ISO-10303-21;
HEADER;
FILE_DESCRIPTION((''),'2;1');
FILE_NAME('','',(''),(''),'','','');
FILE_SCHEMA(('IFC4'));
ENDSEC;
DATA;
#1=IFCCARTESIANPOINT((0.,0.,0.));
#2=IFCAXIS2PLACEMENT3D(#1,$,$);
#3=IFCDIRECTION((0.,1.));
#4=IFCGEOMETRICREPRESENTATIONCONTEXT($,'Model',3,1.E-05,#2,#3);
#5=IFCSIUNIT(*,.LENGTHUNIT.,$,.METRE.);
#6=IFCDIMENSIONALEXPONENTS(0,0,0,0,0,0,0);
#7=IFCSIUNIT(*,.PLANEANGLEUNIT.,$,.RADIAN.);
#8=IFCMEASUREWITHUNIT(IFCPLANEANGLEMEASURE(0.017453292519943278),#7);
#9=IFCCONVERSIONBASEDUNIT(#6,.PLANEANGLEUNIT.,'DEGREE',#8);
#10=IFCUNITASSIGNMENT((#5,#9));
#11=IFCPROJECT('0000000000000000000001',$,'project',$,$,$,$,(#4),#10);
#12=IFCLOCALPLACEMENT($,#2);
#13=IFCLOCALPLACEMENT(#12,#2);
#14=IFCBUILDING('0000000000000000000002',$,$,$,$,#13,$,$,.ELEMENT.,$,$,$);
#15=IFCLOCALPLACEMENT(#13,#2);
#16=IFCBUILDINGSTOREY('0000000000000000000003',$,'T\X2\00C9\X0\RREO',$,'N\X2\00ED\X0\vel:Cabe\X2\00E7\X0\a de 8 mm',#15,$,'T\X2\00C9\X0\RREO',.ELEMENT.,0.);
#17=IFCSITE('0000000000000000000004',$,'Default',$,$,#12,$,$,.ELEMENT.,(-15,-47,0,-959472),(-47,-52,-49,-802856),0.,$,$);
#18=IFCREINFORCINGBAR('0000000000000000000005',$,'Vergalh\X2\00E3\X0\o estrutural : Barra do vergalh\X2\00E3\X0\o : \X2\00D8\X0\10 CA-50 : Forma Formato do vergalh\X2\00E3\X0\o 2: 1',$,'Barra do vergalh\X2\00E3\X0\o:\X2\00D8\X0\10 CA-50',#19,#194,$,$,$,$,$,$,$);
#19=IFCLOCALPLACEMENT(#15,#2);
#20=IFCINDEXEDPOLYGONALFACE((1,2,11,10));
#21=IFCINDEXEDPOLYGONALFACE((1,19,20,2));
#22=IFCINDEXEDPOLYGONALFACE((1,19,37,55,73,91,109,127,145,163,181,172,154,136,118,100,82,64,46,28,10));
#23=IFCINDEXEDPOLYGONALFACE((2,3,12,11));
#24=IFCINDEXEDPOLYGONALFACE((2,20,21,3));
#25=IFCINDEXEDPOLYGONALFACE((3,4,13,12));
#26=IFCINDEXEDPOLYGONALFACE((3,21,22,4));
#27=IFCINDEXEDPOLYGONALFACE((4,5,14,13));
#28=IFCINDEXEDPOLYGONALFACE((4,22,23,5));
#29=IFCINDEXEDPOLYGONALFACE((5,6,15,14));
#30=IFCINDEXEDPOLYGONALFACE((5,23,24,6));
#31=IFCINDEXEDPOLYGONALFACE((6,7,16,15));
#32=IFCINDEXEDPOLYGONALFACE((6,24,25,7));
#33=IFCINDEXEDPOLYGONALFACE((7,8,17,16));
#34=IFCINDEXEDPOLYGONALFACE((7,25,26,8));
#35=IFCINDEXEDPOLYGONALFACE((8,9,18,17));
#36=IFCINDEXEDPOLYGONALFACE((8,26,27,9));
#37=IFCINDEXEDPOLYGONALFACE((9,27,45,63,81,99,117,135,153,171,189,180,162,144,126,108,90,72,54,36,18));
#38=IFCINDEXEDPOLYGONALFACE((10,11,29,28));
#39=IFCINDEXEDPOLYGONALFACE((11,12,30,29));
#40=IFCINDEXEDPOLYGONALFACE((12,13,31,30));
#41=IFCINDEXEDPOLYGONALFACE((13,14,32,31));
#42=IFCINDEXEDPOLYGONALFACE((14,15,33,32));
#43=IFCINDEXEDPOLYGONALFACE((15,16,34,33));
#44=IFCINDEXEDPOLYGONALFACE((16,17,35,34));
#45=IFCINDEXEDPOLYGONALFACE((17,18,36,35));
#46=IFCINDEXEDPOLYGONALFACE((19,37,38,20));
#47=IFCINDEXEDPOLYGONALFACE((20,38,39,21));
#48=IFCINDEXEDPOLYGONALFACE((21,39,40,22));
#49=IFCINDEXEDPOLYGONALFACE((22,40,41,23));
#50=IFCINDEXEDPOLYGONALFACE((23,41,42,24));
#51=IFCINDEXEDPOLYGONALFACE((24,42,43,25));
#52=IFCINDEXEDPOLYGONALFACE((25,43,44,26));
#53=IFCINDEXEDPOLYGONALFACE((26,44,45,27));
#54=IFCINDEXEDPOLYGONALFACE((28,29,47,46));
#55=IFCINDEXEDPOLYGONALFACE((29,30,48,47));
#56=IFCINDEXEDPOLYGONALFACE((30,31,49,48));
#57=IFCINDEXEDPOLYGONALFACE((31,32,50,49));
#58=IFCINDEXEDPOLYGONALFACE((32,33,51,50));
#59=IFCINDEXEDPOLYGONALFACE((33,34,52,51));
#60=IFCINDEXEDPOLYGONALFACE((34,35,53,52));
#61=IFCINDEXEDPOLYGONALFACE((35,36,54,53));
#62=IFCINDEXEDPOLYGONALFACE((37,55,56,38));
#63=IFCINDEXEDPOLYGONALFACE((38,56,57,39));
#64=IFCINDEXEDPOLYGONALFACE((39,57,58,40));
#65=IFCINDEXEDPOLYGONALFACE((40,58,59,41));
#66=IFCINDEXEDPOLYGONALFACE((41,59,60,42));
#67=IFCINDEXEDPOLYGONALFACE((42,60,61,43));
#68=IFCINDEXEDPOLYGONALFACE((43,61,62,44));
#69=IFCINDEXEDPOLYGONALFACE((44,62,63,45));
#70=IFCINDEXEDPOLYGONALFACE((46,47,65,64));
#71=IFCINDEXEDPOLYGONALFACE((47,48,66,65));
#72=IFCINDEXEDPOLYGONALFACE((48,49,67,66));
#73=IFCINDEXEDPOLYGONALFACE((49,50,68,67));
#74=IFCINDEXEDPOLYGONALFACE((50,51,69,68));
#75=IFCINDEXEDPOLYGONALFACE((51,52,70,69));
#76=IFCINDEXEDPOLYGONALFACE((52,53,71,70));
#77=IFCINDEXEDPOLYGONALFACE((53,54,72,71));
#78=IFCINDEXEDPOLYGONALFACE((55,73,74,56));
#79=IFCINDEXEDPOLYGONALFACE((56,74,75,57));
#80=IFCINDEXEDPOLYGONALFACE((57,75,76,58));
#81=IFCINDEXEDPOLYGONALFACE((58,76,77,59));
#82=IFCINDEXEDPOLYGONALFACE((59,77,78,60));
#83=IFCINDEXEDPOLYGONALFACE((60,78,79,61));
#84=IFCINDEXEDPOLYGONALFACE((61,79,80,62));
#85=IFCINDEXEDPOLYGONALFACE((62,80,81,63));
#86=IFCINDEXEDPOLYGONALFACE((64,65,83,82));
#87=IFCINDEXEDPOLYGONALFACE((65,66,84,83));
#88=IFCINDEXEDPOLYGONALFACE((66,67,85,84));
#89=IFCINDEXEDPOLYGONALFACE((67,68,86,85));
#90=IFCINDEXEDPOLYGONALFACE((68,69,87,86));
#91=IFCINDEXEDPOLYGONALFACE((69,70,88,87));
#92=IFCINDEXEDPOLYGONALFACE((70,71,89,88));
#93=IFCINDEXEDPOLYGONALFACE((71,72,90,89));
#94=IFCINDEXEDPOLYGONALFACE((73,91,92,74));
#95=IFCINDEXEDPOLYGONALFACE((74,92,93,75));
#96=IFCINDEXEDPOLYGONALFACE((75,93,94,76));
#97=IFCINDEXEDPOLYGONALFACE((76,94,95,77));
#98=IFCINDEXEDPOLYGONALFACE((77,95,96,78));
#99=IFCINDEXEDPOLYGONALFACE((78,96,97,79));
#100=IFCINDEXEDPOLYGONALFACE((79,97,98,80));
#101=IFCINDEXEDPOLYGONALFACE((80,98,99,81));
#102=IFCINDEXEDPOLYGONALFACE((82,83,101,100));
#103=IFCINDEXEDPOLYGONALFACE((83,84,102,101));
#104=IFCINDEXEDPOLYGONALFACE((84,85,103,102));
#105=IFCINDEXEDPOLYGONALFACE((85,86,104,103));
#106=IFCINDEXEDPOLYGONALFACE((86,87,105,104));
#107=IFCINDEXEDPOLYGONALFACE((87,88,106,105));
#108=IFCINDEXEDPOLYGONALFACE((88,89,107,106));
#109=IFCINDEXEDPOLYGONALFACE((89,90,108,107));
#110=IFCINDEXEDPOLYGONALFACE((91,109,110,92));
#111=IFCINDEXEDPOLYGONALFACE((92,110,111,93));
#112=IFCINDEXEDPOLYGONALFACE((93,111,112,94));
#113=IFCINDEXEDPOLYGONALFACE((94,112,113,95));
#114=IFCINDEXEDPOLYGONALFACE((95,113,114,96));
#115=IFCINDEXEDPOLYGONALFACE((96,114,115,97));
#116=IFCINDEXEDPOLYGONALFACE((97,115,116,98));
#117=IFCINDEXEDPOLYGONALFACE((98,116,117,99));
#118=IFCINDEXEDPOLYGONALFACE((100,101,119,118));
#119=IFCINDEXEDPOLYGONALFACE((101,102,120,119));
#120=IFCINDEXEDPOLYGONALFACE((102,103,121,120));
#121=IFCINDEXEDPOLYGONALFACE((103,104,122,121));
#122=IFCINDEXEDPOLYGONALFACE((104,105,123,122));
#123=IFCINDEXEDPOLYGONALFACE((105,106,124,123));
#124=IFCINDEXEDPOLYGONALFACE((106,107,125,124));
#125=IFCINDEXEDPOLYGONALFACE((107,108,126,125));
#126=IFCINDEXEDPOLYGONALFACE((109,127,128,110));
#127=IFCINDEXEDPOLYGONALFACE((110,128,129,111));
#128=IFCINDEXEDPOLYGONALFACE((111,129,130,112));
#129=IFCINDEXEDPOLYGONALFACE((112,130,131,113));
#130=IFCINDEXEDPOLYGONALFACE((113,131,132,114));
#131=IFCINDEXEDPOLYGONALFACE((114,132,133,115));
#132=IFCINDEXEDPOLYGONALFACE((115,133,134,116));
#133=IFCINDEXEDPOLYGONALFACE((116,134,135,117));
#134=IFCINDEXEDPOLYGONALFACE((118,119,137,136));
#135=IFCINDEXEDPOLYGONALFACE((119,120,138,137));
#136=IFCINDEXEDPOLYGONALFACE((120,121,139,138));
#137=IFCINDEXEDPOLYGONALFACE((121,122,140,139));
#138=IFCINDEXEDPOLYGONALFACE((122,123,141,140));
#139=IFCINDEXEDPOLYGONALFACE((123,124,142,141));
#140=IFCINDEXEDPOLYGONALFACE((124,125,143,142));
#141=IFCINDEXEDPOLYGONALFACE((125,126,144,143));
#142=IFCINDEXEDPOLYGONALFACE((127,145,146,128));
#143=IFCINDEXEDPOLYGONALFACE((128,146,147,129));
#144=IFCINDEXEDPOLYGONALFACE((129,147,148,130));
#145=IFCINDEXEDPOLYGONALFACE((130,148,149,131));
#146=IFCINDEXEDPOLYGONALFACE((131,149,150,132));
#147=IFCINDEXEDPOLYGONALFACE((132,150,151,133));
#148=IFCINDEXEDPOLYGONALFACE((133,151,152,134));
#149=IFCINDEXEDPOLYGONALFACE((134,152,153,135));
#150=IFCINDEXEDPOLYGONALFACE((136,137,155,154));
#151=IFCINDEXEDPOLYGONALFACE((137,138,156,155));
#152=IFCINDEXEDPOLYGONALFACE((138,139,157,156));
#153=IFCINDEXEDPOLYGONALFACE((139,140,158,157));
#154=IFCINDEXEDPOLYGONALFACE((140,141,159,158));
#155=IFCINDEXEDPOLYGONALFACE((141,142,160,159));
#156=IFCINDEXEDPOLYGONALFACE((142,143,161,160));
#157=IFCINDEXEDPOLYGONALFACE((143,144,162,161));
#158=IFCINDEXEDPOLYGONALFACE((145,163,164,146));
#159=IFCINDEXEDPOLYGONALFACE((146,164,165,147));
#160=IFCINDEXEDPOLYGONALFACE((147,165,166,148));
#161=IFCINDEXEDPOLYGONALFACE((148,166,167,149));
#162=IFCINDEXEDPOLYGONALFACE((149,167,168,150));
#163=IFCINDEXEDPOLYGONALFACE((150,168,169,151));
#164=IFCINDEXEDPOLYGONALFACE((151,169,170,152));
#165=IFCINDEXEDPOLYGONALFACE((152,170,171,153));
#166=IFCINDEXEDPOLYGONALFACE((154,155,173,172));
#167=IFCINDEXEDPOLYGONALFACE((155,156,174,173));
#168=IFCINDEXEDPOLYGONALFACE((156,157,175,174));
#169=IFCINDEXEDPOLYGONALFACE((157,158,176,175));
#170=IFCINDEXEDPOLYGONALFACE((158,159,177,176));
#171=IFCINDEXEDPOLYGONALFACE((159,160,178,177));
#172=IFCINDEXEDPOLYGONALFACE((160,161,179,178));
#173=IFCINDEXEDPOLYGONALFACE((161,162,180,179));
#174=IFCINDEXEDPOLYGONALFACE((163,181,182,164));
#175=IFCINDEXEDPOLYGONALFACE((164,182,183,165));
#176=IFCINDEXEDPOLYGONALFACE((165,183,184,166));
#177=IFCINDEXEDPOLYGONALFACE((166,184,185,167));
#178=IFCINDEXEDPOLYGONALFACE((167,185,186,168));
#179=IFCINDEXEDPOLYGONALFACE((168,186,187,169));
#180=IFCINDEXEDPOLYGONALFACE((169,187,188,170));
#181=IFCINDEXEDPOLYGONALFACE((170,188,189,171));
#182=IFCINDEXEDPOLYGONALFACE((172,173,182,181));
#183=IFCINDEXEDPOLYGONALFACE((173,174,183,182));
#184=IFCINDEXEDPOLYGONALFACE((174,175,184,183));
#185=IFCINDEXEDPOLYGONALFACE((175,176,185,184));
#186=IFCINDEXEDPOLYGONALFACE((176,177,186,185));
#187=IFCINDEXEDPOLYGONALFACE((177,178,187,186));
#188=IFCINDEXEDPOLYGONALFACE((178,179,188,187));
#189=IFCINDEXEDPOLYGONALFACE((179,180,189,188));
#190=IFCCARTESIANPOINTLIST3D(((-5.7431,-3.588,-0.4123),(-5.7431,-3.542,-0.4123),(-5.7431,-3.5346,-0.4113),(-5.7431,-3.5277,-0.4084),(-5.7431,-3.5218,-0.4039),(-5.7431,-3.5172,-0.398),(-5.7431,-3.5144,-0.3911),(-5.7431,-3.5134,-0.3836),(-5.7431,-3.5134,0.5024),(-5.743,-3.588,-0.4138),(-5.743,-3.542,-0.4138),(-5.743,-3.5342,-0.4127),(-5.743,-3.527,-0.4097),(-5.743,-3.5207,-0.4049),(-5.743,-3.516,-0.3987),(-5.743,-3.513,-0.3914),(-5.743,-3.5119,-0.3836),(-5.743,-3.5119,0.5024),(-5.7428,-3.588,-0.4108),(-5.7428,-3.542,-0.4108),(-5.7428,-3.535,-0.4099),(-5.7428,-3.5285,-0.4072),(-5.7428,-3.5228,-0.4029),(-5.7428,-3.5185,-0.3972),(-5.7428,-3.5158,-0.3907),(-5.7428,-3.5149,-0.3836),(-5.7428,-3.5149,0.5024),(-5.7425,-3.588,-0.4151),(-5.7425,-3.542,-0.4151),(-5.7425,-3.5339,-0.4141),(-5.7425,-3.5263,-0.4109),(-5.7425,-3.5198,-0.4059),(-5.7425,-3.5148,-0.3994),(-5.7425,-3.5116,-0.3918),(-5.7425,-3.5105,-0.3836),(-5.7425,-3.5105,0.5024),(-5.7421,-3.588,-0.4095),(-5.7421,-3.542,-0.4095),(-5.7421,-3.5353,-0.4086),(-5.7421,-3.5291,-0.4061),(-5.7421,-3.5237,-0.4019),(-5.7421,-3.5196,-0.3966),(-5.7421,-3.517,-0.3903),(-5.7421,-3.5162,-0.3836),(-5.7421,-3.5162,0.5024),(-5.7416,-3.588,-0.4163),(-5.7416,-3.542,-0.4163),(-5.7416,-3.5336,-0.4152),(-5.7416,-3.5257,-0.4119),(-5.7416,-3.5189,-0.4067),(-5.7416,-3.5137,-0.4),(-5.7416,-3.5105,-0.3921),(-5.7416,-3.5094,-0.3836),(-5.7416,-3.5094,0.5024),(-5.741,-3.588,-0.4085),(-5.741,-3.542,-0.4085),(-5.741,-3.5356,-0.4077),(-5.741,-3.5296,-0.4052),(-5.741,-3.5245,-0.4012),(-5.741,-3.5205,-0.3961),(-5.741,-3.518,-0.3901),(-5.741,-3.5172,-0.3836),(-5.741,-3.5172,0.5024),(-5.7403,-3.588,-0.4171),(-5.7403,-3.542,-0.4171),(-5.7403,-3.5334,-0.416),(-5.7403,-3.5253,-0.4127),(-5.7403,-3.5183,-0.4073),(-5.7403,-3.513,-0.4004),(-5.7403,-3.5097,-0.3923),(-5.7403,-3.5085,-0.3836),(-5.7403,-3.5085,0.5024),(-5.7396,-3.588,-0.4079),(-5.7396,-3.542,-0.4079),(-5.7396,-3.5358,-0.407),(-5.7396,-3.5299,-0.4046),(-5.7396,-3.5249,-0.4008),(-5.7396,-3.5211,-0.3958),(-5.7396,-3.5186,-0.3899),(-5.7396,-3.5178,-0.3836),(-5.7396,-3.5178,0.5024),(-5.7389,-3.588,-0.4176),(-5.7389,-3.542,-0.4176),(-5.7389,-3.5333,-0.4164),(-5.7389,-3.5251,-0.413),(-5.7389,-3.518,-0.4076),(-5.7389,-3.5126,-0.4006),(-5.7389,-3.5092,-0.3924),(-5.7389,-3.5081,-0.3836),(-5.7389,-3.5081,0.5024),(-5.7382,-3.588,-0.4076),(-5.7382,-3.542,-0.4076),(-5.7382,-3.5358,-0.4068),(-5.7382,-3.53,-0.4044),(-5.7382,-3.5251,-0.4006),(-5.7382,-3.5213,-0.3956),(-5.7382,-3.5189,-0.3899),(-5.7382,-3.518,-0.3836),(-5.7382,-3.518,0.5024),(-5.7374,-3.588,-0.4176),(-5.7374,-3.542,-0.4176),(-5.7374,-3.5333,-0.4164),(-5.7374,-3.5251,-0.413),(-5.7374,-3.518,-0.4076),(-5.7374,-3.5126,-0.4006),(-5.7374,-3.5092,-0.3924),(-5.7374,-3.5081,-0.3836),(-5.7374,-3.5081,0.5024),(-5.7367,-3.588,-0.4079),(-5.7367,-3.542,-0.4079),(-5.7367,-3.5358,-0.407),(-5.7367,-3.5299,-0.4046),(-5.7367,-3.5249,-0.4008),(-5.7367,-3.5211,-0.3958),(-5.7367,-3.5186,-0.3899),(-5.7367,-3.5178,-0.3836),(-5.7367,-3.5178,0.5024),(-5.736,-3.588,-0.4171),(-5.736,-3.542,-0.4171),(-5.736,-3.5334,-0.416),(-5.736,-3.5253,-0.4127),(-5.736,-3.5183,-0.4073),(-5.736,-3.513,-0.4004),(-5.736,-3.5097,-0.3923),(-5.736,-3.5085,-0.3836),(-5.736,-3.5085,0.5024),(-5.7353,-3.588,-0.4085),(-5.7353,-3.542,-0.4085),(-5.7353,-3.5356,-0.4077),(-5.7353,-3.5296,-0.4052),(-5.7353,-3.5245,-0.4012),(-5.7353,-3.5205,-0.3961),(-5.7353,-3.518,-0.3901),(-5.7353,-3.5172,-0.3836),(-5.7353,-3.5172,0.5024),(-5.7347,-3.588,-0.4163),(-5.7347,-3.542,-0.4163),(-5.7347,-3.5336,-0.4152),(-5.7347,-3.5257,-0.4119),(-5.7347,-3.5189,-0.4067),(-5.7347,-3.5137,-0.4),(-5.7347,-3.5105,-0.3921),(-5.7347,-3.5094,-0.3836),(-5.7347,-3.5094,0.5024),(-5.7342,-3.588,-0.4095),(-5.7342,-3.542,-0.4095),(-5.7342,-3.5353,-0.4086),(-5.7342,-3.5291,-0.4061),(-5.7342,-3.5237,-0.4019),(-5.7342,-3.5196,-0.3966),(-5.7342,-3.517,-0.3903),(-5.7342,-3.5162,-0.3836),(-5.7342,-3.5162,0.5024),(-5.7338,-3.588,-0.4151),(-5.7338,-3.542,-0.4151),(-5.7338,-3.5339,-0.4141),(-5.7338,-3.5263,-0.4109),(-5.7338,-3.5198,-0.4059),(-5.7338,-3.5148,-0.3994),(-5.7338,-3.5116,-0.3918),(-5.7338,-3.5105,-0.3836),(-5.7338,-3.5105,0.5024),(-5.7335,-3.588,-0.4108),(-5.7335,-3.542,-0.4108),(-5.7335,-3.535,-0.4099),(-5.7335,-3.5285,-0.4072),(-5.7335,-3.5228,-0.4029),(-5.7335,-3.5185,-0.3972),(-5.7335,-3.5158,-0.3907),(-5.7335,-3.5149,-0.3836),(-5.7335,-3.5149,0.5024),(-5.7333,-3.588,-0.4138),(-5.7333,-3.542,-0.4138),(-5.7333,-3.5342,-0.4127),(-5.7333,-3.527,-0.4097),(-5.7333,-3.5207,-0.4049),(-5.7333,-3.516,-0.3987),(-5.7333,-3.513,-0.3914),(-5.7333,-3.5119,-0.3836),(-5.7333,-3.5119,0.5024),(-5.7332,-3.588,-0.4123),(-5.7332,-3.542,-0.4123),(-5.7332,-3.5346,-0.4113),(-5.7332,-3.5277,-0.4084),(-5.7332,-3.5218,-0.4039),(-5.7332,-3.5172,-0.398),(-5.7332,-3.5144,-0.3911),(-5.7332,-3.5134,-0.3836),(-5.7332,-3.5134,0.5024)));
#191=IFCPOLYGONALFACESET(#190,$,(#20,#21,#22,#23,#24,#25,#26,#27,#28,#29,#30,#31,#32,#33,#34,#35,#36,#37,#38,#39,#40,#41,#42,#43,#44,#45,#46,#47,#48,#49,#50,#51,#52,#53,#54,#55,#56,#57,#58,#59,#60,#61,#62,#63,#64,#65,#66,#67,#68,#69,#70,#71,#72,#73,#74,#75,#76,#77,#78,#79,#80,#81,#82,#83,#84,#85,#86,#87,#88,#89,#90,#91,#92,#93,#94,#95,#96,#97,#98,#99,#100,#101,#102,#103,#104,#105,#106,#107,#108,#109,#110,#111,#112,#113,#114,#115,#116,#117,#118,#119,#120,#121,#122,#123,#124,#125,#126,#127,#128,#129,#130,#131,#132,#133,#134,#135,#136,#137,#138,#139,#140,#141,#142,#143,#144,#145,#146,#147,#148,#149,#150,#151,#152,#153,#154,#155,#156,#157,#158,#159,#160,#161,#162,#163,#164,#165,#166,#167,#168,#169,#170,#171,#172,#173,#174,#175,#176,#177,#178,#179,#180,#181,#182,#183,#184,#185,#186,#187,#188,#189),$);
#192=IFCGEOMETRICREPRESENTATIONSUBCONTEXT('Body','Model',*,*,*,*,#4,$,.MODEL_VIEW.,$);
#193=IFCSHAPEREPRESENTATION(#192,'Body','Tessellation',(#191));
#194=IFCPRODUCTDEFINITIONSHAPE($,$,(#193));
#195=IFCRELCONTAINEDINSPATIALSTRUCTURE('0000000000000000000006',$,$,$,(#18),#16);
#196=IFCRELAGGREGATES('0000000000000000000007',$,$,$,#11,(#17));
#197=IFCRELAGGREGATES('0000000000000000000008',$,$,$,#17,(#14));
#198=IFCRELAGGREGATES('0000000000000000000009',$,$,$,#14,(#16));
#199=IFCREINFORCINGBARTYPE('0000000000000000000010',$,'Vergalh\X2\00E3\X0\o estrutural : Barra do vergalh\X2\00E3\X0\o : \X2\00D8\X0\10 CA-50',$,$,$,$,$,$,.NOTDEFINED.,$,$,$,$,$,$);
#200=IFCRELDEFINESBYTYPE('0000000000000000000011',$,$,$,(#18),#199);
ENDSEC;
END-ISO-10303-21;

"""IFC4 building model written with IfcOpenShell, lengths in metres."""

from ifc_helpers import new_model, entity, si_unit, converted_unit, direction, origin, place, context, subcontext, project, spatial, type_object, element, save


model = new_model("IFC4")

# Units and contexts
model_context = context("Model", 3, precision=1e-05, world=origin(), true_north=direction((0.0, 1.0)))
body_context = subcontext(model_context, "Body", "Model", "MODEL_VIEW")
ifc_project = project(units=[si_unit("LENGTHUNIT", "METRE"), converted_unit("PLANEANGLEUNIT", "DEGREE", entity("IfcPlaneAngleMeasure", 0.017453292519943278), si_unit("PLANEANGLEUNIT", "RADIAN"), dimensions=[0, 0, 0, 0, 0, 0, 0])], contexts=[model_context])

# Site, building, storey
site_placement = place(None, origin())
site = spatial("IfcSite", under=ifc_project, at=site_placement, Name="Default", CompositionType="ELEMENT", RefLatitude=(-15, -47, 0, -959472), RefLongitude=(-47, -52, -49, -802856), RefElevation=0.0)
building_placement = place(site_placement, origin())
building = spatial("IfcBuilding", under=site, at=building_placement, CompositionType="ELEMENT")
storey_placement = place(building_placement, origin())
storey = spatial("IfcBuildingStorey", under=building, at=storey_placement, Name="TÉRREO", ObjectType="Nível:Cabeça de 8 mm", LongName="TÉRREO", CompositionType="ELEMENT", Elevation=0.0)

# Reinforcing bar
reinforcing_bar_type_1 = type_object("IfcReinforcingBarType", Name="Vergalhão estrutural : Barra do vergalhão : Ø10 CA-50", PredefinedType="NOTDEFINED")
reinforcing_bar_1_placement = place(storey_placement, origin())
element("IfcReinforcingBar", 1, at=reinforcing_bar_1_placement, inside=storey, type_object=reinforcing_bar_type_1, Name="Vergalhão estrutural : Barra do vergalhão : Ø10 CA-50 : Forma Formato do vergalhão 2: 1", ObjectType="Barra do vergalhão:Ø10 CA-50", context=body_context, shape_type="AdvancedSweptSolid", body=[
    entity("IfcSweptDiskSolid", entity("IfcIndexedPolyCurve", entity("IfcCartesianPointList3D", [[-5.7382, -3.588, -0.4126], [-5.7382, -3.542, -0.4126], [-5.7382, -3.5215, -0.4042], [-5.7382, -3.513, -0.3836], [-5.7382, -3.513, 0.5024]]), [entity("IfcLineIndex", [1, 2]), entity("IfcArcIndex", [2, 3, 4]), entity("IfcLineIndex", [4, 5])], False), 0.005, None, 0.0, 92.0),
])

save(model, "model.ifc")
